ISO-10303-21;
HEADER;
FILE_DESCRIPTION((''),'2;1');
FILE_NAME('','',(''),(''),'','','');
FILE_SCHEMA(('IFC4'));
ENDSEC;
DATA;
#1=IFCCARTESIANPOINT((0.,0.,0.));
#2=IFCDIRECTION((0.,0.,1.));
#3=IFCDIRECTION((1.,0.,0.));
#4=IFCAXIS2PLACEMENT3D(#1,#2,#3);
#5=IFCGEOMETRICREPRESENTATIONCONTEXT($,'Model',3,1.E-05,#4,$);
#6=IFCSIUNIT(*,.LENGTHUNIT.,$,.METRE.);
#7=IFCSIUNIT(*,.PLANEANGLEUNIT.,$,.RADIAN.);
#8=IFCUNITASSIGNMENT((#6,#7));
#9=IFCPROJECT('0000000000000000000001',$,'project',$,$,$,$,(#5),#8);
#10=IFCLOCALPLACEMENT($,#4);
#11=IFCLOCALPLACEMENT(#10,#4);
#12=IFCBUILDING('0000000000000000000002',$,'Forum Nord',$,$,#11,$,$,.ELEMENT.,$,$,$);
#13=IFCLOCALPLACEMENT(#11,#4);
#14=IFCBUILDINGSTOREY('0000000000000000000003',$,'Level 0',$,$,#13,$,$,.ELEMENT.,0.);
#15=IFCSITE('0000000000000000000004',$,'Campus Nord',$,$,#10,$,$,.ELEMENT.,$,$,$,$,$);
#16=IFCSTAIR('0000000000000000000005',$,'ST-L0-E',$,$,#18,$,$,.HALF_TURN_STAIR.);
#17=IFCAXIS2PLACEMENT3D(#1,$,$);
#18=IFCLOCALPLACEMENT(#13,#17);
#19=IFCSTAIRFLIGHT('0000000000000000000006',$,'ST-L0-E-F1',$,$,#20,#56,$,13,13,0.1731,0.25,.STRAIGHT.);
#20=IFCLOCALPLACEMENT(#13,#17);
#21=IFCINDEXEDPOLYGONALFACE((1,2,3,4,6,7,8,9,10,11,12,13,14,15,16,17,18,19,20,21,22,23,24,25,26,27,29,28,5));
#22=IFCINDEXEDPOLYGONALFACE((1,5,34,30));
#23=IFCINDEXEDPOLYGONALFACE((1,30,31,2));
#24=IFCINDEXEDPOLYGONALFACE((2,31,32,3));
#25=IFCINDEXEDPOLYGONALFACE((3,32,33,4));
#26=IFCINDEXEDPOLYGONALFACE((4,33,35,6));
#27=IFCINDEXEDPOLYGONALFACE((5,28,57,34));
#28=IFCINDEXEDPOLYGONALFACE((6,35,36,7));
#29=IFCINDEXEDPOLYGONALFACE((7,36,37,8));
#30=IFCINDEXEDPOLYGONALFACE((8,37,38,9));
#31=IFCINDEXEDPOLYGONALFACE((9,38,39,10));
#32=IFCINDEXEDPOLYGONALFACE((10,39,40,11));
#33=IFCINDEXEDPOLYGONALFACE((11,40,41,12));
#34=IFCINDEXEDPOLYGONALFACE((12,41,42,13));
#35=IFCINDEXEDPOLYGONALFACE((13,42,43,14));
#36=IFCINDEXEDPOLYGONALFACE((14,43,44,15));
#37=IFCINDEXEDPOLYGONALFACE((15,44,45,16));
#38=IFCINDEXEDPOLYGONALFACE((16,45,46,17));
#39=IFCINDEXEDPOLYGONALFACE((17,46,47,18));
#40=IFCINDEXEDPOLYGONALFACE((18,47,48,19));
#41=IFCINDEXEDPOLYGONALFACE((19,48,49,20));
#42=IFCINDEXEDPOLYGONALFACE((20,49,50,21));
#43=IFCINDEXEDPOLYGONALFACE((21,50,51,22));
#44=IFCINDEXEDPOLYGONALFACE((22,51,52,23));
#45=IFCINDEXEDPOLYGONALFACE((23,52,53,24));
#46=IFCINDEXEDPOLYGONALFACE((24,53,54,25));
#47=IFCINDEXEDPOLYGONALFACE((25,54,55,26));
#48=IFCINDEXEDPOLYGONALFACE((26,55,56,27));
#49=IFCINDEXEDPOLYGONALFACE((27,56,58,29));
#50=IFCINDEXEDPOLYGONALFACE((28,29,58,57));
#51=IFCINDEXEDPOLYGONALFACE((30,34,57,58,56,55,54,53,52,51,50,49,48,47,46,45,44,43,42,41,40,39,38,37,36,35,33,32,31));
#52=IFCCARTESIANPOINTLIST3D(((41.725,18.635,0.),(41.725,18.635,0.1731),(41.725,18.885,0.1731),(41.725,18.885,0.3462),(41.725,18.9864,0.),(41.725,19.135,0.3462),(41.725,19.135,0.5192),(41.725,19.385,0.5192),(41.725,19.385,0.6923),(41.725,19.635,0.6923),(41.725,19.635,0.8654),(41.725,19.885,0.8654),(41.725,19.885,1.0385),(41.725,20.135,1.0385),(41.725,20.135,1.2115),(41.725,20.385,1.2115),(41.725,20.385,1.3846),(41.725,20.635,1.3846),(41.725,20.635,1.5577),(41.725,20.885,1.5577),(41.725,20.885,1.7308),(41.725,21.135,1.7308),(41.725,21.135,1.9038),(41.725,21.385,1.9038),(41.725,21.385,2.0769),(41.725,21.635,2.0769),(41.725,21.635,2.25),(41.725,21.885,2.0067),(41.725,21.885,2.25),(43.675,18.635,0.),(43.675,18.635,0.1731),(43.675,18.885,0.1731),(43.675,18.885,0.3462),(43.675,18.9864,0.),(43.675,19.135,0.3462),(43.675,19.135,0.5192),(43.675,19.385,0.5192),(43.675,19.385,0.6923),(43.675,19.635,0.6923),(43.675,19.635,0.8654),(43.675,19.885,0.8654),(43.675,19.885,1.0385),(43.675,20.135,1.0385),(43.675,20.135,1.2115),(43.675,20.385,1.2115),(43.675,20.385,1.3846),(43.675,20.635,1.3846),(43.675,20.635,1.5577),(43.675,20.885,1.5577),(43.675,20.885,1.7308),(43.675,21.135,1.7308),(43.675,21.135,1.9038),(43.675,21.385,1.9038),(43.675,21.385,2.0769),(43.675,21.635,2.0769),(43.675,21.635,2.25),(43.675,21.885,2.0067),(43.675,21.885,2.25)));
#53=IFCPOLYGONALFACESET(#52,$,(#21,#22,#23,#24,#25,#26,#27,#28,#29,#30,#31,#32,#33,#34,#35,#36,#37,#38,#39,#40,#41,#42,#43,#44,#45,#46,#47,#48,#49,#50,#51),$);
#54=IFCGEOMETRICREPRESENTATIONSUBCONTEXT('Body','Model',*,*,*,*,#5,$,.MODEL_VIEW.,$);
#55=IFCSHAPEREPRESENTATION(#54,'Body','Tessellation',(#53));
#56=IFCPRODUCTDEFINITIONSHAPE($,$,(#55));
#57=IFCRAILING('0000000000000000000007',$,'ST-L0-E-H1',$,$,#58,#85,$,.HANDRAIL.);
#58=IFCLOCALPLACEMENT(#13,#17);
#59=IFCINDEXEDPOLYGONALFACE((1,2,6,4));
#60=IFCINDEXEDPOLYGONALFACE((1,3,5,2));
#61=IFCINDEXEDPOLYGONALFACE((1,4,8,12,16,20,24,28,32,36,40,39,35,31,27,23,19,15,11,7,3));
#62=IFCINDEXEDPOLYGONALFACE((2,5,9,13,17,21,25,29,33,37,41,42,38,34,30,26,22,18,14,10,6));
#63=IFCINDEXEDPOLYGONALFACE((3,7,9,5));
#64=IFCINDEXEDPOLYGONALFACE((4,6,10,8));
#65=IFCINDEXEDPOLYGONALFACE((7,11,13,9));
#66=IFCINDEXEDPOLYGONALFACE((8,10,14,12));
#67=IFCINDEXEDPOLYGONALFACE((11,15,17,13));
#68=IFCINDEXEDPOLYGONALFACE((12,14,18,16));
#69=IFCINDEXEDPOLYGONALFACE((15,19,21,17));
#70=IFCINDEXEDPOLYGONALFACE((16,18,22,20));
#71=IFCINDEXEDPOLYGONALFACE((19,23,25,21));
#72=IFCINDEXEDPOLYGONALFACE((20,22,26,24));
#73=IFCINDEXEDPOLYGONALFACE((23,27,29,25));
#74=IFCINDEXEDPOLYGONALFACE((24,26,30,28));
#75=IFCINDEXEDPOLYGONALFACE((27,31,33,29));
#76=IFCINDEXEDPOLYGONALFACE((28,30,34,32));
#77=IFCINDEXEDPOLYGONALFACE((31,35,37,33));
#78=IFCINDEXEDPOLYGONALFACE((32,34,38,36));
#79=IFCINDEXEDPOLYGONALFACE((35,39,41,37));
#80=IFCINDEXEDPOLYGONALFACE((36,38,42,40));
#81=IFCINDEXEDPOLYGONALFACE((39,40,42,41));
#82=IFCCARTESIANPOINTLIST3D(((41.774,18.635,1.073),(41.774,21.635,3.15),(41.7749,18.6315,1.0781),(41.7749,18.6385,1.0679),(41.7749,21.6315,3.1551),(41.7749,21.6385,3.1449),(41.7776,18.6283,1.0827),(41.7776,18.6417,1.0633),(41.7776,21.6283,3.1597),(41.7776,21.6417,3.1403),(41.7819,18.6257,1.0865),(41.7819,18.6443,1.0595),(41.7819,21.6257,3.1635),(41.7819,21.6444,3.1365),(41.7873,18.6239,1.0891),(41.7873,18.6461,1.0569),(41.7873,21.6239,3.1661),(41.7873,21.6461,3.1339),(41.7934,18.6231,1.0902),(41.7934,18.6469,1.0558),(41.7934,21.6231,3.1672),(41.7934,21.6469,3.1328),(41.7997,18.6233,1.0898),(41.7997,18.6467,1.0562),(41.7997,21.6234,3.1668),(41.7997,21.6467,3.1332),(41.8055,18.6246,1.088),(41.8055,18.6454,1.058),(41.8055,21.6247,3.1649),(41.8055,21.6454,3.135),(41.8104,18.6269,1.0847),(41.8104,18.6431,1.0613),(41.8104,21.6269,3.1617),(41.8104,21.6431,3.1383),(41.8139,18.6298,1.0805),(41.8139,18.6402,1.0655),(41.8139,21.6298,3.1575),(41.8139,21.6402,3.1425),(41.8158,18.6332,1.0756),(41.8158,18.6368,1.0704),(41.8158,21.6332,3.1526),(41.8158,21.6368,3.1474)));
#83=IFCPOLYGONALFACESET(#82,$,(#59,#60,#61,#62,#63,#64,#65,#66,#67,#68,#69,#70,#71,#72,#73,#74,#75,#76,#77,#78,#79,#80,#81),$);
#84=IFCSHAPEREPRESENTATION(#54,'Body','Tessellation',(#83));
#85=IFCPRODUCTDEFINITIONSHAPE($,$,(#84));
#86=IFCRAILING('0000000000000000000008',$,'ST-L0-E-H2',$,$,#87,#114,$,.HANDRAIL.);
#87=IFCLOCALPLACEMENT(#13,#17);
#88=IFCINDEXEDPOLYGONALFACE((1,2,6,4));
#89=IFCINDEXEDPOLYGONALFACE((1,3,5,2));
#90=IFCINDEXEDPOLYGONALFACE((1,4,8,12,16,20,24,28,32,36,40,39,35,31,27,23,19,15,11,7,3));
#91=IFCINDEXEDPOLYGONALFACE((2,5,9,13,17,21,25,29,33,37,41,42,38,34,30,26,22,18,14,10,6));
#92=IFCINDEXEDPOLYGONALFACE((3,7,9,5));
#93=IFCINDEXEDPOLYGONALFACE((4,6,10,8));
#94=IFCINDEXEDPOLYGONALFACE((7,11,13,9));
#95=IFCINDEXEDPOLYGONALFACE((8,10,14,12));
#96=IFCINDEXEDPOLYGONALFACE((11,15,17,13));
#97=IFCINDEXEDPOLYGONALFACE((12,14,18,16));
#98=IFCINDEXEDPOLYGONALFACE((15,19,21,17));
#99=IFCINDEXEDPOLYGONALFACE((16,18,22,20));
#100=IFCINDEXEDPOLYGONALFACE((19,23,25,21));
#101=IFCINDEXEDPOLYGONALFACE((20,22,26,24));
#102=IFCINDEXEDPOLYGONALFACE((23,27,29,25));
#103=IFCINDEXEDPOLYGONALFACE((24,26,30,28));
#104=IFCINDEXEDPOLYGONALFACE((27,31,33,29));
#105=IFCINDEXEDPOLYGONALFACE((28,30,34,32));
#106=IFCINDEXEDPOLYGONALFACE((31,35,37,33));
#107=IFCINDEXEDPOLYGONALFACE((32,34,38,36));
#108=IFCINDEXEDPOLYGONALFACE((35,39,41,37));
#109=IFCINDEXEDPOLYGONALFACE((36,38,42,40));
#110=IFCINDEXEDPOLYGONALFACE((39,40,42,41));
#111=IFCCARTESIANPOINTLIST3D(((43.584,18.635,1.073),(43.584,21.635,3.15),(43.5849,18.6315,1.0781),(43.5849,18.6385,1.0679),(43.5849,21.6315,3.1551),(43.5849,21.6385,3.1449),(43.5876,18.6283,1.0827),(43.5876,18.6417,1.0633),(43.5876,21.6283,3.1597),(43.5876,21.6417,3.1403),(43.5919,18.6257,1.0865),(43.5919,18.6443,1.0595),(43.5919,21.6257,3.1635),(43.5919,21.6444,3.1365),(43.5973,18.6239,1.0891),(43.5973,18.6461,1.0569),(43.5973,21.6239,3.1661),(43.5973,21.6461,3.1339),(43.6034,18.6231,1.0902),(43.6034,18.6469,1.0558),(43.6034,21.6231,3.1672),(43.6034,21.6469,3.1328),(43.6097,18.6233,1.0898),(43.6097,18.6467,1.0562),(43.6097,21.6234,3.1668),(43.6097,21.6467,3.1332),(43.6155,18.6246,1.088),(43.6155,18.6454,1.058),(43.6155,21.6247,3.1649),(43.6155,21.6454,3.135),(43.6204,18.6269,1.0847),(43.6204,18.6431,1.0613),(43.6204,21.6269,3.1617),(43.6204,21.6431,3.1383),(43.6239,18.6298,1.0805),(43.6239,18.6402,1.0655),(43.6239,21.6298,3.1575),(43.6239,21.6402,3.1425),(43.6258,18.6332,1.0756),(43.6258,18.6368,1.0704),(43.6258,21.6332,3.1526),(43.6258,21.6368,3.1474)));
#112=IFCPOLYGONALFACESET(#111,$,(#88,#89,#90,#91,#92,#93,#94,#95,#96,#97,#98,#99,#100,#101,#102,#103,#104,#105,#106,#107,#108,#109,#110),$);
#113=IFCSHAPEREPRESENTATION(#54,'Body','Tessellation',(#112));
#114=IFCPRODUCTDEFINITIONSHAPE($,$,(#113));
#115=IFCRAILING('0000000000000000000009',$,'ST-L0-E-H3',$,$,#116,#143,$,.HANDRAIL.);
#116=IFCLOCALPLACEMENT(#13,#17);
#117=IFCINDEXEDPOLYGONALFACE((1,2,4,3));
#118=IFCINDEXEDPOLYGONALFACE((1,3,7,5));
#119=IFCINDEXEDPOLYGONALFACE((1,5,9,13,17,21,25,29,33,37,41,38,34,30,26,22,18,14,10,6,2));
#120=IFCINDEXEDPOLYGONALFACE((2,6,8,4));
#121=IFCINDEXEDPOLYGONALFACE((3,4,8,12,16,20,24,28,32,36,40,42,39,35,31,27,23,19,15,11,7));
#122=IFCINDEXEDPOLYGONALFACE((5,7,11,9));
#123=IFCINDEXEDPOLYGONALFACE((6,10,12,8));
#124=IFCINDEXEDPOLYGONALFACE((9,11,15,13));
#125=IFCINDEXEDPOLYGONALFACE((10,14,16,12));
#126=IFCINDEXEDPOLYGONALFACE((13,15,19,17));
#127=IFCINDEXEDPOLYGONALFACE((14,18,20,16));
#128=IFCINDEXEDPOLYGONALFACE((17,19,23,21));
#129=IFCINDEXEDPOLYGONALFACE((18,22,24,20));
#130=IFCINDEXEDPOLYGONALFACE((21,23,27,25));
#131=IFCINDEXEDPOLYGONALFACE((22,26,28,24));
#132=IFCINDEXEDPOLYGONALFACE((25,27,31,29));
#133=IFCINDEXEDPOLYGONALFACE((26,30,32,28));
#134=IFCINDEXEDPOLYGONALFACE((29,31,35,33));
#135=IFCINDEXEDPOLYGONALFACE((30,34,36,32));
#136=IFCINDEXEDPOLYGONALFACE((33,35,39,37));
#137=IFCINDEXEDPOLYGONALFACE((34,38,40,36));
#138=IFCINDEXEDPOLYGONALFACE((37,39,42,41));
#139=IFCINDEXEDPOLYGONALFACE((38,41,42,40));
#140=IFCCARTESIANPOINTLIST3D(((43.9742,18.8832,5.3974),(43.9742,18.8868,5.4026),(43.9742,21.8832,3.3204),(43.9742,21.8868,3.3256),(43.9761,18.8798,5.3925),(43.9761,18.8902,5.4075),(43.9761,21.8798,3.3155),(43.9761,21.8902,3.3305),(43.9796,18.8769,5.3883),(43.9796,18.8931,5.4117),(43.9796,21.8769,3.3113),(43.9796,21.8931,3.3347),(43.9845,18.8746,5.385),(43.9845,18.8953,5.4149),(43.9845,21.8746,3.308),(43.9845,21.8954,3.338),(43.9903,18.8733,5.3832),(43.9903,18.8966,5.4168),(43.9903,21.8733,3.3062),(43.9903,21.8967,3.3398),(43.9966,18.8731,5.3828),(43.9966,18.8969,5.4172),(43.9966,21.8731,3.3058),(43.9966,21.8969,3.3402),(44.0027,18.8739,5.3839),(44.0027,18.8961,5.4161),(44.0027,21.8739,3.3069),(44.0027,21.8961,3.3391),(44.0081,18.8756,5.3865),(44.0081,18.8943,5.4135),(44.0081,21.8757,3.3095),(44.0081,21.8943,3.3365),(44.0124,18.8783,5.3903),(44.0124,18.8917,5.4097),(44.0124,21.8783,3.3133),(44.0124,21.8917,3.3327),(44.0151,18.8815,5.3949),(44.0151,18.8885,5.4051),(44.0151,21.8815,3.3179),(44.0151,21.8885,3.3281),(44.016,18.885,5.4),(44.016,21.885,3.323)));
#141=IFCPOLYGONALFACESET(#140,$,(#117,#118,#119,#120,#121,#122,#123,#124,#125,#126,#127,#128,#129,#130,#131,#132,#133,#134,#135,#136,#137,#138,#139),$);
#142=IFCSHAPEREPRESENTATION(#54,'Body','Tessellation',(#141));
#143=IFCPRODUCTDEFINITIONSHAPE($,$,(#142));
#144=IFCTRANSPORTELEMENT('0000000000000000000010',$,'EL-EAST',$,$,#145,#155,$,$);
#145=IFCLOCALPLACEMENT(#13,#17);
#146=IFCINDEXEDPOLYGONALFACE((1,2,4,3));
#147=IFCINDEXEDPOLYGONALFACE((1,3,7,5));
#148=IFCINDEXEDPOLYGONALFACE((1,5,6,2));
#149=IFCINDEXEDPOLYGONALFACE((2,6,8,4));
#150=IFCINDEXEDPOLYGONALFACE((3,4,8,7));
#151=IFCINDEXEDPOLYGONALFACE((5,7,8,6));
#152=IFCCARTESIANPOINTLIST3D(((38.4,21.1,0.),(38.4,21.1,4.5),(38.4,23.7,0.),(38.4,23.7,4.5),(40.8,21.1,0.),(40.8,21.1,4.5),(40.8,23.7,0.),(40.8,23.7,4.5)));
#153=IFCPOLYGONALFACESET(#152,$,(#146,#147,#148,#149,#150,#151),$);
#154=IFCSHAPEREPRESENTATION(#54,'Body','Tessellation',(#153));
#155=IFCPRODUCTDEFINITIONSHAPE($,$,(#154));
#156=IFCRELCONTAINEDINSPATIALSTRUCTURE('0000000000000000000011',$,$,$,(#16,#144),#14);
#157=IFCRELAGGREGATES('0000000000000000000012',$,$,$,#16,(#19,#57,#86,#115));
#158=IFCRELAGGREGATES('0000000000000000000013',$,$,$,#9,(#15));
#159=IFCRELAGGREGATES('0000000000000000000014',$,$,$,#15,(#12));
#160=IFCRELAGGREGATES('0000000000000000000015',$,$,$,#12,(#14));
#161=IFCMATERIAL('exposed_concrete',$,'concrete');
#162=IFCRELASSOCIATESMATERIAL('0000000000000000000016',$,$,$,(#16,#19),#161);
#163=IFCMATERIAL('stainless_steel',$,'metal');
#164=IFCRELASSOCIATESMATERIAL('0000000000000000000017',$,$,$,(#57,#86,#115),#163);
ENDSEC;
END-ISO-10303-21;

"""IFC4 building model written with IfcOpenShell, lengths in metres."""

from ifc_helpers import new_model, si_unit, frame, frame_2d, origin_with_axes, origin_2d_with_axis, place, context, subcontext, project, spatial, polyline, rectangle, circle, outline, extrude, material, element, aggregate, save


model = new_model("IFC4")

# Units and contexts
model_context = context("Model", 3, precision=1e-05, world=origin_with_axes())
body_context = subcontext(model_context, "Body", "Model", "MODEL_VIEW")
ifc_project = project(units=[si_unit("LENGTHUNIT", "METRE"), si_unit("PLANEANGLEUNIT", "RADIAN")], contexts=[model_context])

# Site, building, storey
site_placement = place(None, origin_with_axes())
site = spatial("IfcSite", under=ifc_project, at=site_placement, Name="Campus Nord", CompositionType="ELEMENT")
building_placement = place(site_placement, origin_with_axes())
building = spatial("IfcBuilding", under=site, at=building_placement, Name="Forum Nord", CompositionType="ELEMENT")
storey_placement = place(building_placement, origin_with_axes())
storey = spatial("IfcBuildingStorey", under=building, at=storey_placement, Name="Level 0", CompositionType="ELEMENT", Elevation=0.0)

# Shared definitions
ifc_material_1 = material(Name="exposed_concrete", Category="concrete")

# Stair, stair flight, railings
stair_placement = place(storey_placement, origin_with_axes())
stair = element("IfcStair", 1, at=stair_placement, inside=storey, material=ifc_material_1, Name="ST-L0-E", PredefinedType="HALF_TURN_STAIR")
stair_flight_placement = place(storey_placement, frame((41.725, 18.635, 0.0), z_axis=(0.0, 0.0, 1.0), x_axis=(1.0, 0.0, 0.0)))
stair_flight = element("IfcStairFlight", 2, at=stair_flight_placement, material=ifc_material_1, Name="ST-L0-E-F1", NumberOfRisers=13, NumberOfTreads=13, PredefinedType="STRAIGHT", RiserHeight=0.1731, TreadLength=0.25, context=body_context, shape_type="SweptSolid", body=[
    extrude(outline(polyline([(0.0, 0.0), (0.3514, 0.0), (3.25, 2.0067), (3.25, 2.25), (3.0, 2.25), (3.0, 2.0769), (2.75, 2.0769), (2.75, 1.9039), (2.5, 1.9039), (2.5, 1.7308), (2.25, 1.7308), (2.25, 1.5577), (2.0, 1.5577), (2.0, 1.3846), (1.75, 1.3846), (1.75, 1.2115), (1.5, 1.2115), (1.5, 1.0385), (1.25, 1.0385), (1.25, 0.8654), (1.0, 0.8654), (1.0, 0.6923), (0.75, 0.6923), (0.75, 0.5192), (0.5, 0.5192), (0.5, 0.3462), (0.25, 0.3462), (0.25, 0.1731), (0.0, 0.1731), (0.0, 0.0)])), frame((0.0, 0.0, 0.0), z_axis=(1.0, 0.0, 0.0), x_axis=(0.0, 1.0, 0.0)), (0.0, 0.0, 1.0), 1.95),
])
ifc_material_2 = material(Name="stainless_steel", Category="metal")
railing_1_placement = place(storey_placement, frame((41.795, 18.635, 1.073), z_axis=(0.0, 0.82218, 0.56922), x_axis=(-1.0, 0.0, 0.0)))
railing_1 = element("IfcRailing", 3, at=railing_1_placement, material=ifc_material_2, Name="ST-L0-E-H1", PredefinedType="HANDRAIL", context=body_context, shape_type="SweptSolid", body=[
    extrude(circle(Radius=0.021, at=origin_2d_with_axis()), origin_with_axes(), (0.0, 0.0, 1.0), 3.6488),
])
railing_2_placement = place(storey_placement, frame((43.605, 18.635, 1.073), z_axis=(0.0, 0.82218, 0.56922), x_axis=(-1.0, 0.0, 0.0)))
railing_2 = element("IfcRailing", 4, at=railing_2_placement, material=ifc_material_2, Name="ST-L0-E-H2", PredefinedType="HANDRAIL", context=body_context, shape_type="SweptSolid", body=[
    extrude(circle(Radius=0.021, at=origin_2d_with_axis()), origin_with_axes(), (0.0, 0.0, 1.0), 3.6488),
])
railing_3_placement = place(storey_placement, frame((43.995, 21.885, 3.323), z_axis=(0.0, -0.82218, 0.56922), x_axis=(1.0, 0.0, 0.0)))
railing_3 = element("IfcRailing", 5, at=railing_3_placement, material=ifc_material_2, Name="ST-L0-E-H3", PredefinedType="HANDRAIL", context=body_context, shape_type="SweptSolid", body=[
    extrude(circle(Radius=0.021, at=origin_2d_with_axis()), origin_with_axes(), (0.0, 0.0, 1.0), 3.6488),
])
aggregate(stair, [stair_flight, railing_1, railing_2, railing_3])

# Transport element
transport_element_placement = place(storey_placement, frame((38.4, 21.1, 0.0), z_axis=(0.0, 0.0, 1.0), x_axis=(1.0, 0.0, 0.0)))
element("IfcTransportElement", 6, at=transport_element_placement, inside=storey, Name="EL-EAST", context=body_context, shape_type="SweptSolid", body=[
    extrude(rectangle(XDim=2.4, YDim=2.6, at=frame_2d((1.2, 1.3), x_axis=(1.0, 0.0))), origin_with_axes(), (0.0, 0.0, 1.0), 4.5),
])

save(model, "model.ifc")
